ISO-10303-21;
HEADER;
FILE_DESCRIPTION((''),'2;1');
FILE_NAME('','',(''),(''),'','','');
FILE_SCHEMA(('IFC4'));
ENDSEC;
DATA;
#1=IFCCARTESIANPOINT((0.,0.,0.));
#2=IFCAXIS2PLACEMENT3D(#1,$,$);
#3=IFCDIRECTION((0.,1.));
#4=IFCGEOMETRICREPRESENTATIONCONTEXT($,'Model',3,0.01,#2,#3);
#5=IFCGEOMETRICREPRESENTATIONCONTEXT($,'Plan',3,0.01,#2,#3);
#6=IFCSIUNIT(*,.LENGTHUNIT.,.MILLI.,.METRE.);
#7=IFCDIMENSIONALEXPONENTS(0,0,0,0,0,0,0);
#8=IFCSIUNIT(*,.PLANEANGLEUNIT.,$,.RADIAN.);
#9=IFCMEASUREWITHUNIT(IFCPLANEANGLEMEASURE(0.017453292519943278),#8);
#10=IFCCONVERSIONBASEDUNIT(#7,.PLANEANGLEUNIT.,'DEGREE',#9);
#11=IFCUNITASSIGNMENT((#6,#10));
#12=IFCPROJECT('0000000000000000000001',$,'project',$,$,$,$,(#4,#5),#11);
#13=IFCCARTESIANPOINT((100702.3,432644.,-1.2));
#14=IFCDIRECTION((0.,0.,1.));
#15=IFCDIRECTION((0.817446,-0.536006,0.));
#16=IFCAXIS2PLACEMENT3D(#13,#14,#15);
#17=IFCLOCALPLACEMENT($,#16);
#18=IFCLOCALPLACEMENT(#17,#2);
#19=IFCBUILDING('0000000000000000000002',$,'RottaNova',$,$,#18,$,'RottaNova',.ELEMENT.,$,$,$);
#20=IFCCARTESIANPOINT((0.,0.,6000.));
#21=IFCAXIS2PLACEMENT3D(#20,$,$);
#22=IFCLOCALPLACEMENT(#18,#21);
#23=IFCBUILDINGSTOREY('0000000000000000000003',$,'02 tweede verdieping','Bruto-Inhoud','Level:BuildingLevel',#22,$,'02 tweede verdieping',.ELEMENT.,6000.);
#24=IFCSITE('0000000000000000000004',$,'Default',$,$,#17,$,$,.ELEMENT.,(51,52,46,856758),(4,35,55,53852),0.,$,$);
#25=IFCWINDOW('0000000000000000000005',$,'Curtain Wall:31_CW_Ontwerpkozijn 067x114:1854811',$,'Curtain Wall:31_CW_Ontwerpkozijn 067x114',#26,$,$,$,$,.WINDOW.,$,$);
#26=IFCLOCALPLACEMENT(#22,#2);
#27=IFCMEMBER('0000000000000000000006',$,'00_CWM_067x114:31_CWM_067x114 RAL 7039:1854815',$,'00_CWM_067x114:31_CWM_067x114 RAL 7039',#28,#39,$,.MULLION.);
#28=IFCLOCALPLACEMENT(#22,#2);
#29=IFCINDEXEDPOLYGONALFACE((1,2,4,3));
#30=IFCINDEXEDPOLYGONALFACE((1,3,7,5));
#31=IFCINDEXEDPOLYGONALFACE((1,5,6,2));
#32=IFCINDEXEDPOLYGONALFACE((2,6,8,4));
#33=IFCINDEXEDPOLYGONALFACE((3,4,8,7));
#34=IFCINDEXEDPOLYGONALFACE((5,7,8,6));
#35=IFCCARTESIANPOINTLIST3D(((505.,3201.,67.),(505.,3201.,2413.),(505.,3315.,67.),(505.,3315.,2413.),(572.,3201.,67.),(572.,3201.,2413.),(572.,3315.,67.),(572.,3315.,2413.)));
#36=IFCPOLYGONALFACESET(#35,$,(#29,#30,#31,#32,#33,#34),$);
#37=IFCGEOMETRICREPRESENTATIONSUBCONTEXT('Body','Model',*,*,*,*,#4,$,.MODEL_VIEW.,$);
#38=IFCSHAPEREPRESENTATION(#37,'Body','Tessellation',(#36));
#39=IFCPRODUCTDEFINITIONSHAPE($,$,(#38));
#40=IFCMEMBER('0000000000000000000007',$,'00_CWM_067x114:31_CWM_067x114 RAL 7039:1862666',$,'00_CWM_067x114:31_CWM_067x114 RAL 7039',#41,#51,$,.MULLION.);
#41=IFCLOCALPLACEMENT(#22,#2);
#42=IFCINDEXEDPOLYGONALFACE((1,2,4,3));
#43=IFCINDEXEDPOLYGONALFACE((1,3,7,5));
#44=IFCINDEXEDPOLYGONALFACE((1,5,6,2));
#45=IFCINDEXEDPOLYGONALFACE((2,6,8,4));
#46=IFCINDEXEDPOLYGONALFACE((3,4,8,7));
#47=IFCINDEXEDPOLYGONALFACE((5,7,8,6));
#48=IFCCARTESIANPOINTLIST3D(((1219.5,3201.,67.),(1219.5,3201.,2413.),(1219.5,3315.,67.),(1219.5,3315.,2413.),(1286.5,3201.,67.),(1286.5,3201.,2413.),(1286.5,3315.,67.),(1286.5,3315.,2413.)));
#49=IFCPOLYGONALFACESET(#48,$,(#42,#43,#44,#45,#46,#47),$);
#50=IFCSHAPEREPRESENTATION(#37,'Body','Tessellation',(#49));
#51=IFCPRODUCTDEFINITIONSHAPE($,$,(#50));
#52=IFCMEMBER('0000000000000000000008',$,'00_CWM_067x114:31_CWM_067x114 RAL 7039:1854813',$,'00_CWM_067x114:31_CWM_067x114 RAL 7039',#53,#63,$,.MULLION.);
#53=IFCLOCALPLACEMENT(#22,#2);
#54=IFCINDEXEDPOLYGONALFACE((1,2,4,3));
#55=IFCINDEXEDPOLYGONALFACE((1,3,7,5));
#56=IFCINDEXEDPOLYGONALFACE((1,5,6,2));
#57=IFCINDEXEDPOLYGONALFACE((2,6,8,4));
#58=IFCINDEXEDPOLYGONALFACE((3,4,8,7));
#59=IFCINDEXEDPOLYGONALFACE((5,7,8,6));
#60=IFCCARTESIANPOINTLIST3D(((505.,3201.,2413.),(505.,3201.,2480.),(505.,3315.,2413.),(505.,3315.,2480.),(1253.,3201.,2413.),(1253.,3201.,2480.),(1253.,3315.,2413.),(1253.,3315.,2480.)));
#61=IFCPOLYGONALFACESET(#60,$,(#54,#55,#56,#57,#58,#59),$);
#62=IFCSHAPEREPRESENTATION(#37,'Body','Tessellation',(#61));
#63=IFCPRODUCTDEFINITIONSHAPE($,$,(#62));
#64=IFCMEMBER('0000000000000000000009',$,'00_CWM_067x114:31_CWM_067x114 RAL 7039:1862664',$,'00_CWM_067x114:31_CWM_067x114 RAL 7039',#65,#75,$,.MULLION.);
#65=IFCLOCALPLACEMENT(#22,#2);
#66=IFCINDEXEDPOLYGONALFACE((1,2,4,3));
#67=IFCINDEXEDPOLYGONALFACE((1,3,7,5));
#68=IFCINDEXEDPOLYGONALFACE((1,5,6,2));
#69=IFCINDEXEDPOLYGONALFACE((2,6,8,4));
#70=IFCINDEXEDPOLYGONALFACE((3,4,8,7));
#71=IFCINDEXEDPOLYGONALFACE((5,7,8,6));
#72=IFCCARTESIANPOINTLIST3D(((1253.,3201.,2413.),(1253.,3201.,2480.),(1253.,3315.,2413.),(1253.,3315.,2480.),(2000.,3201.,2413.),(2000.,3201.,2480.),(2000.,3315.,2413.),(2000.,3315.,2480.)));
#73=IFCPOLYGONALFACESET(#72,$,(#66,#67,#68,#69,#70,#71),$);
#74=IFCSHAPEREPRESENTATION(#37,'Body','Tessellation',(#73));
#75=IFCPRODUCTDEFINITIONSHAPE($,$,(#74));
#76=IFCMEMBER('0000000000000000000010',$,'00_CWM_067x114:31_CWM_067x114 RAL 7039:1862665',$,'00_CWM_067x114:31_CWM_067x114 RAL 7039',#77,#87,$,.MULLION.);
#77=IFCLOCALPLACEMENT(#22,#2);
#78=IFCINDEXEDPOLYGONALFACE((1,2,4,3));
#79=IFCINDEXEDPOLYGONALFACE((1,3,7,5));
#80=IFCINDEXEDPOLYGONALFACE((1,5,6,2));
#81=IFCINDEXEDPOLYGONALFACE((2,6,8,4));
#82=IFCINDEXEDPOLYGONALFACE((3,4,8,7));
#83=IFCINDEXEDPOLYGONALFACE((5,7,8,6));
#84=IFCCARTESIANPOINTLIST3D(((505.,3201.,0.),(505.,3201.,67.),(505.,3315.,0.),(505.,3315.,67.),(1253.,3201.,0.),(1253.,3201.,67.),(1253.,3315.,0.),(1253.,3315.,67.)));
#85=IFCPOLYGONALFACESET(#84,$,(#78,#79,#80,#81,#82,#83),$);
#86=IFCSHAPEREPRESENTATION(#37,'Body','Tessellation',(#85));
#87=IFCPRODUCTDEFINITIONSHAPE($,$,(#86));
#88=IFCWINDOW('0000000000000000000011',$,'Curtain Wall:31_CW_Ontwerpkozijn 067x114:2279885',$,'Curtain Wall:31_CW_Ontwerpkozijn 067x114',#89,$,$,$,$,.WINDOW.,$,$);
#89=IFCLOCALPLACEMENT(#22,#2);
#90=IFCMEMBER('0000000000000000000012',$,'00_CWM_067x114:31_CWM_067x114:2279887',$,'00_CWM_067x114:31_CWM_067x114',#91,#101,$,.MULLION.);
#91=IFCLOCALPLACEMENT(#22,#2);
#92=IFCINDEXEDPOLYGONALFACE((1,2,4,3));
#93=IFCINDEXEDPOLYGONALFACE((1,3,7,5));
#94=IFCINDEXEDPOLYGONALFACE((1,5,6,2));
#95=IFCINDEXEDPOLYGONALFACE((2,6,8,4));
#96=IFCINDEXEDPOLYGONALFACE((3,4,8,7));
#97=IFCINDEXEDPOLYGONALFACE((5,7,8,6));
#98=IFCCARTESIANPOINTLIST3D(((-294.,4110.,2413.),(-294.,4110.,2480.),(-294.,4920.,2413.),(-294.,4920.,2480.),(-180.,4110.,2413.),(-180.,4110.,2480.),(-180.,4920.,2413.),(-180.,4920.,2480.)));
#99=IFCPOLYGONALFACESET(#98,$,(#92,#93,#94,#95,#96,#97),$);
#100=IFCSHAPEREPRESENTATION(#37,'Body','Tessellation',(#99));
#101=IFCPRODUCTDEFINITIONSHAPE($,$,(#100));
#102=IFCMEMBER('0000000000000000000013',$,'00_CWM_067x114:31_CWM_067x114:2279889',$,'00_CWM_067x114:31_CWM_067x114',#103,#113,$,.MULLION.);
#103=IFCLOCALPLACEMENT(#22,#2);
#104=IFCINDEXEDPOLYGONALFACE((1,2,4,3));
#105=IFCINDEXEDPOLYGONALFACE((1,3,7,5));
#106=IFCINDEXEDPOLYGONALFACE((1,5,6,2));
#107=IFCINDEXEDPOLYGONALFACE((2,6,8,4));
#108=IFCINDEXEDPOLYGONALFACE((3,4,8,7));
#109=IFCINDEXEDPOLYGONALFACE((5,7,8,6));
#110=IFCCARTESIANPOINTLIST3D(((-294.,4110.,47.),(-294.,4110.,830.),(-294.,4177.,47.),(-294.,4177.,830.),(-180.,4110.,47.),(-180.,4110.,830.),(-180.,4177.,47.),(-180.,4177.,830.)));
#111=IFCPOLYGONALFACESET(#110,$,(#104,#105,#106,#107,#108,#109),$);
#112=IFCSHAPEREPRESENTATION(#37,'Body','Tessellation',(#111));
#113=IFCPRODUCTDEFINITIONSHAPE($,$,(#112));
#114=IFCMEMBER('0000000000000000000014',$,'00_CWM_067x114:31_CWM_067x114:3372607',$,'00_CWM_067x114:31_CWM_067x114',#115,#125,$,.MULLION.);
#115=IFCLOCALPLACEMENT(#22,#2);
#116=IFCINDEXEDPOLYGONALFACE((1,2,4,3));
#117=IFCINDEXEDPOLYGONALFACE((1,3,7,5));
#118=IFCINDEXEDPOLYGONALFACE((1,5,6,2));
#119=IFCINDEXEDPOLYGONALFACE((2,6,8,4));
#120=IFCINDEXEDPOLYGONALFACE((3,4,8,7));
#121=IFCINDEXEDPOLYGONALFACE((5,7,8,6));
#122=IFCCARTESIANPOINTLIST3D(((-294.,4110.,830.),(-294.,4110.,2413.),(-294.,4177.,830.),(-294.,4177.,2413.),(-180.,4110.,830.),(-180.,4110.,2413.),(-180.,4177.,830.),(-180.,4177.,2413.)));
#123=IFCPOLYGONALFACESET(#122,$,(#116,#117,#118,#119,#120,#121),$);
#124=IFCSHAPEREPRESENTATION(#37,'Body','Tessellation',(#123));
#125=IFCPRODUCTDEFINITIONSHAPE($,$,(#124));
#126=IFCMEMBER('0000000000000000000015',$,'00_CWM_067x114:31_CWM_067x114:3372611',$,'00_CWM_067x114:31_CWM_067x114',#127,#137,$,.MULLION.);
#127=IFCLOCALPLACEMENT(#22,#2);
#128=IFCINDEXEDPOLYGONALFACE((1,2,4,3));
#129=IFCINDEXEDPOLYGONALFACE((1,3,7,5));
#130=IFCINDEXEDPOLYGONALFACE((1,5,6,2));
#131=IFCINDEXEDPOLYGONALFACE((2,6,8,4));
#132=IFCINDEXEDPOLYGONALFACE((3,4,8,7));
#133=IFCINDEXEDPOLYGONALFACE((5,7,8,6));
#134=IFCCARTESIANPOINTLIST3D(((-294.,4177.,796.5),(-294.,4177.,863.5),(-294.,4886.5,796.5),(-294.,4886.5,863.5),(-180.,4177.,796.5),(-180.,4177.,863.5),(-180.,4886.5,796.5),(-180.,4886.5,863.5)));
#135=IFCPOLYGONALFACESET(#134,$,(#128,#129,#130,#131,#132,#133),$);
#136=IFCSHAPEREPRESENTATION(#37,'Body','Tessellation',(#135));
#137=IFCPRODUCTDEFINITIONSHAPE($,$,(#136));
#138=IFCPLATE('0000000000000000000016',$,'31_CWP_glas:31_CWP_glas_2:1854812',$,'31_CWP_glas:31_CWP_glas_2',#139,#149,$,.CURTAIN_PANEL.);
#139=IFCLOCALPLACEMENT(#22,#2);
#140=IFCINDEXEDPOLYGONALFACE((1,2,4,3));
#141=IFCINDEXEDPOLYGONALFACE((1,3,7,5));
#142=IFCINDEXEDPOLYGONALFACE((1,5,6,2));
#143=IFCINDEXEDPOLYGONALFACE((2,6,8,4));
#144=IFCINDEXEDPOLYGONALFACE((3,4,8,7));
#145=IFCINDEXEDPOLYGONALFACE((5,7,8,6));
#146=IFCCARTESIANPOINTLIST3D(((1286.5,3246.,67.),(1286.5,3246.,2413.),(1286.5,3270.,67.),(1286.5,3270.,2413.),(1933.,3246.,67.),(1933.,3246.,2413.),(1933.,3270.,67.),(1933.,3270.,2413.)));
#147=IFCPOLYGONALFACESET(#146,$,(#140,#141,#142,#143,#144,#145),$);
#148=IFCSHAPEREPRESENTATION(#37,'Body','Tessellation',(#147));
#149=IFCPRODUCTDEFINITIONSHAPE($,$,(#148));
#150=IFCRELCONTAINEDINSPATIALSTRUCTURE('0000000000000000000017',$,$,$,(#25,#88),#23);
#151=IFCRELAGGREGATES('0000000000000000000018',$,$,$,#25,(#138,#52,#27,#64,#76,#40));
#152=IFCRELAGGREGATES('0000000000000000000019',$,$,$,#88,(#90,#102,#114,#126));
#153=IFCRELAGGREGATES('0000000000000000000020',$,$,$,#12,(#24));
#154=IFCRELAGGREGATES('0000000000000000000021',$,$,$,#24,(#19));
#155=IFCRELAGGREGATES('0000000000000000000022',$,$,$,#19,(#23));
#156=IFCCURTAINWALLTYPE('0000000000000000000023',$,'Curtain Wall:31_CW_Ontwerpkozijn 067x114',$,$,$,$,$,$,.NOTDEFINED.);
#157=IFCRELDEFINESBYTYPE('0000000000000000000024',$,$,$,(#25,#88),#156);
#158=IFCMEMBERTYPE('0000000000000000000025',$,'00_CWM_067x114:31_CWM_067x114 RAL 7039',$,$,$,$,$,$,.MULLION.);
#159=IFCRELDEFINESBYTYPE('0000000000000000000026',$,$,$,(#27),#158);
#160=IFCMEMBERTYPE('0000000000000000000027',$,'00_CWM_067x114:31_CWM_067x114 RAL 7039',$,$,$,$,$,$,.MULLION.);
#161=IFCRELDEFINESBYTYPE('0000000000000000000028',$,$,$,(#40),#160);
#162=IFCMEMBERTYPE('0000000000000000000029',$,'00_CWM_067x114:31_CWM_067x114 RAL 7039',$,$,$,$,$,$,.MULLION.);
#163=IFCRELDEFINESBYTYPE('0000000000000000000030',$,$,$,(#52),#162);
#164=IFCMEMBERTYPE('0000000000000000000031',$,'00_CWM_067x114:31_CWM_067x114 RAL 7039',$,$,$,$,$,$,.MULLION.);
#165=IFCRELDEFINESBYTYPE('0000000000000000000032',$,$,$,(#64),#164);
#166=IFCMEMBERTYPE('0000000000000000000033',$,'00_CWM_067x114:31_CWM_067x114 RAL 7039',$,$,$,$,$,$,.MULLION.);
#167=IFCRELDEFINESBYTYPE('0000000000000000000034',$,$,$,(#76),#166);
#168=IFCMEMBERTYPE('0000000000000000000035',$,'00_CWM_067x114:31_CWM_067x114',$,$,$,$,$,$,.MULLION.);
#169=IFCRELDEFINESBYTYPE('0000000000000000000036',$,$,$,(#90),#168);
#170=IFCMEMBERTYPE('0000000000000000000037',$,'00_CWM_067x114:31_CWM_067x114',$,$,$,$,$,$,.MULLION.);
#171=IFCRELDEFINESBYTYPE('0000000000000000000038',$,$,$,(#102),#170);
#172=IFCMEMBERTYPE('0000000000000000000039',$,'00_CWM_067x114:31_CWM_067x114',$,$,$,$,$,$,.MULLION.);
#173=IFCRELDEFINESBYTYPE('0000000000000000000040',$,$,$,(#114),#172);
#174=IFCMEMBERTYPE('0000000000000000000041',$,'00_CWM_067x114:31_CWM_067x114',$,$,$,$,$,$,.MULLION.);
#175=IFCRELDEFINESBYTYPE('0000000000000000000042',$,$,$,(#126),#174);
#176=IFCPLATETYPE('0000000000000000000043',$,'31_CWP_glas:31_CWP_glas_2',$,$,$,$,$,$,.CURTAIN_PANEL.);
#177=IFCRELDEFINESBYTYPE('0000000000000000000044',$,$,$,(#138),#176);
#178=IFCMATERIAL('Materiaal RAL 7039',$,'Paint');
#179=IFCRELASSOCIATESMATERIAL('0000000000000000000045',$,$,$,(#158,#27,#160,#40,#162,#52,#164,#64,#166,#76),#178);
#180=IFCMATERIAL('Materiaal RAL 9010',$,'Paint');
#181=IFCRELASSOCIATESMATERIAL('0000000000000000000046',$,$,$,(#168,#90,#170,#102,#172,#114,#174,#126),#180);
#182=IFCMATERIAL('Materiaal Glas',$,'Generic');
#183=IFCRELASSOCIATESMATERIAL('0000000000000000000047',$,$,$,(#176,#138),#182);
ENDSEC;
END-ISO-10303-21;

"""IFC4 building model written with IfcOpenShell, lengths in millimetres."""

from ifc_helpers import new_model, entity, si_unit, converted_unit, direction, frame, origin, place, context, subcontext, project, spatial, indexed_curve, outline, extrude, source, transform, mapped, material, type_object, type_shapes, element, aggregate, save


model = new_model("IFC4")

# Units and contexts
model_context = context("Model", 3, precision=0.01, world=origin(), true_north=direction((0.0, 1.0)))
plan_context = context("Plan", 3, precision=0.01, world=origin(), true_north=direction((0.0, 1.0)))
body_context = subcontext(model_context, "Body", "Model", "MODEL_VIEW")
ifc_project = project(units=[si_unit("LENGTHUNIT", "METRE", prefix="MILLI"), converted_unit("PLANEANGLEUNIT", "DEGREE", entity("IfcPlaneAngleMeasure", 0.017453292519943278), si_unit("PLANEANGLEUNIT", "RADIAN"), dimensions=[0, 0, 0, 0, 0, 0, 0])], contexts=[model_context, plan_context])

# Site, building, storey
site_placement = place(None, frame((100702.3, 432644.0, -1.2), z_axis=(0.0, 0.0, 1.0), x_axis=(0.817446, -0.536006, 0.0)))
site = spatial("IfcSite", under=ifc_project, at=site_placement, Name="Default", CompositionType="ELEMENT", RefLatitude=(51, 52, 46, 856758), RefLongitude=(4, 35, 55, 53852), RefElevation=0.0)
building_placement = place(site_placement, origin())
building = spatial("IfcBuilding", under=site, at=building_placement, Name="RottaNova", LongName="RottaNova", CompositionType="ELEMENT")
storey_placement = place(building_placement, frame((0.0, 0.0, 6000.0)))
storey = spatial("IfcBuildingStorey", under=building, at=storey_placement, Name="02 tweede verdieping", Description="Bruto-Inhoud", ObjectType="Level:BuildingLevel", LongName="02 tweede verdieping", CompositionType="ELEMENT", Elevation=6000.0)

# Windows, members
curtain_wall_type = type_object("IfcCurtainWallType", Name="Curtain Wall:31_CW_Ontwerpkozijn 067x114", PredefinedType="NOTDEFINED")
window_1_placement = place(storey_placement, frame((0.0, 0.0, -6000.0)))
window_1 = element("IfcWindow", 1, at=window_1_placement, inside=storey, type_object=curtain_wall_type, Name="Curtain Wall:31_CW_Ontwerpkozijn 067x114:1854811", ObjectType="Curtain Wall:31_CW_Ontwerpkozijn 067x114", PredefinedType="WINDOW")
ifc_material_1 = material(Name="Materiaal RAL 7039", Category="Paint")
member_type_1 = type_object("IfcMemberType", Name="00_CWM_067x114:31_CWM_067x114 RAL 7039", PredefinedType="MULLION", material=ifc_material_1)
shared_shape_1 = source(origin(), body_context, "Body", "SweptSolid", [
    extrude(outline(indexed_curve([(-33.5, -57.0), (33.5, -57.0), (33.5, 57.0), (-33.5, 57.0), (-33.5, -57.0)], self_intersect=False)), frame((-33.5, -57.0, -2346.0), z_axis=(0.0, 0.0, 1.0), x_axis=(-1.0, 0.0, 0.0)), (0.0, 0.0, 1.0), 2346.0),
])
type_shapes(member_type_1, [shared_shape_1])
member_1_placement = place(window_1_placement, frame((505.0, 3315.0, 6067.0), z_axis=(0.0, 0.0, -1.0), x_axis=(-1.0, 0.0, 0.0)))
member_1 = element("IfcMember", 2, at=member_1_placement, type_object=member_type_1, material=ifc_material_1, Name="00_CWM_067x114:31_CWM_067x114 RAL 7039:1854815", ObjectType="00_CWM_067x114:31_CWM_067x114 RAL 7039", PredefinedType="MULLION", context=body_context, shape_type="MappedRepresentation", body=[
    mapped(shared_shape_1, transform((0.0, 0.0, 0.0), scale=1.0)),
])
member_type_2 = type_object("IfcMemberType", Name="00_CWM_067x114:31_CWM_067x114 RAL 7039", PredefinedType="MULLION", material=ifc_material_1)
shared_shape_2 = source(origin(), body_context, "Body", "SweptSolid", [
    extrude(outline(indexed_curve([(-33.5, -57.0), (33.5, -57.0), (33.5, 57.0), (-33.5, 57.0), (-33.5, -57.0)], self_intersect=False)), frame((0.0, -57.0, -2346.0), z_axis=(0.0, 0.0, 1.0), x_axis=(-1.0, 0.0, 0.0)), (0.0, 0.0, 1.0), 2346.0),
])
type_shapes(member_type_2, [shared_shape_2])
member_2_placement = place(window_1_placement, frame((1253.0, 3315.0, 6067.0), z_axis=(0.0, 0.0, -1.0), x_axis=(-1.0, 0.0, 0.0)))
member_2 = element("IfcMember", 3, at=member_2_placement, type_object=member_type_2, material=ifc_material_1, Name="00_CWM_067x114:31_CWM_067x114 RAL 7039:1862666", ObjectType="00_CWM_067x114:31_CWM_067x114 RAL 7039", PredefinedType="MULLION", context=body_context, shape_type="MappedRepresentation", body=[
    mapped(shared_shape_2, transform((0.0, 0.0, 0.0), scale=1.0)),
])
member_type_3 = type_object("IfcMemberType", Name="00_CWM_067x114:31_CWM_067x114 RAL 7039", PredefinedType="MULLION", material=ifc_material_1)
shared_shape_3 = source(origin(), body_context, "Body", "SweptSolid", [
    extrude(outline(indexed_curve([(-33.5, -57.0), (33.5, -57.0), (33.5, 57.0), (-33.5, 57.0), (-33.5, -57.0)], self_intersect=False)), frame((-33.5, -57.0, -748.0), z_axis=(0.0, 0.0, 1.0), x_axis=(-1.0, 0.0, 0.0)), (0.0, 0.0, 1.0), 748.0),
])
type_shapes(member_type_3, [shared_shape_3])
member_3_placement = place(window_1_placement, frame((505.0, 3315.0, 8480.0), z_axis=(-1.0, 0.0, 0.0), x_axis=(0.0, 0.0, 1.0)))
member_3 = element("IfcMember", 4, at=member_3_placement, type_object=member_type_3, material=ifc_material_1, Name="00_CWM_067x114:31_CWM_067x114 RAL 7039:1854813", ObjectType="00_CWM_067x114:31_CWM_067x114 RAL 7039", PredefinedType="MULLION", context=body_context, shape_type="MappedRepresentation", body=[
    mapped(shared_shape_3, transform((0.0, 0.0, 0.0), scale=1.0)),
])
member_type_4 = type_object("IfcMemberType", Name="00_CWM_067x114:31_CWM_067x114 RAL 7039", PredefinedType="MULLION", material=ifc_material_1)
shared_shape_4 = source(origin(), body_context, "Body", "SweptSolid", [
    extrude(outline(indexed_curve([(-33.5, -57.0), (33.5, -57.0), (33.5, 57.0), (-33.5, 57.0), (-33.5, -57.0)], self_intersect=False)), frame((-33.5, -57.0, -747.0), z_axis=(0.0, 0.0, 1.0), x_axis=(-1.0, 0.0, 0.0)), (0.0, 0.0, 1.0), 747.0),
])
type_shapes(member_type_4, [shared_shape_4])
member_4_placement = place(window_1_placement, frame((1253.0, 3315.0, 8480.0), z_axis=(-1.0, 0.0, 0.0), x_axis=(0.0, 0.0, 1.0)))
member_4 = element("IfcMember", 5, at=member_4_placement, type_object=member_type_4, material=ifc_material_1, Name="00_CWM_067x114:31_CWM_067x114 RAL 7039:1862664", ObjectType="00_CWM_067x114:31_CWM_067x114 RAL 7039", PredefinedType="MULLION", context=body_context, shape_type="MappedRepresentation", body=[
    mapped(shared_shape_4, transform((0.0, 0.0, 0.0), scale=1.0)),
])
member_type_5 = type_object("IfcMemberType", Name="00_CWM_067x114:31_CWM_067x114 RAL 7039", PredefinedType="MULLION", material=ifc_material_1)
shared_shape_5 = source(origin(), body_context, "Body", "SweptSolid", [
    extrude(outline(indexed_curve([(-33.5, -57.0), (33.5, -57.0), (33.5, 57.0), (-33.5, 57.0), (-33.5, -57.0)], self_intersect=False)), frame((-33.5, -57.0, -748.0), z_axis=(0.0, 0.0, 1.0), x_axis=(-1.0, 0.0, 0.0)), (0.0, 0.0, 1.0), 748.0),
])
type_shapes(member_type_5, [shared_shape_5])
member_5_placement = place(window_1_placement, frame((1253.0, 3315.0, 6000.0), z_axis=(1.0, 0.0, 0.0), x_axis=(0.0, 0.0, -1.0)))
member_5 = element("IfcMember", 6, at=member_5_placement, type_object=member_type_5, material=ifc_material_1, Name="00_CWM_067x114:31_CWM_067x114 RAL 7039:1862665", ObjectType="00_CWM_067x114:31_CWM_067x114 RAL 7039", PredefinedType="MULLION", context=body_context, shape_type="MappedRepresentation", body=[
    mapped(shared_shape_5, transform((0.0, 0.0, 0.0), scale=1.0)),
])
window_2_placement = place(storey_placement, frame((0.0, 0.0, -6000.0)))
window_2 = element("IfcWindow", 7, at=window_2_placement, inside=storey, type_object=curtain_wall_type, Name="Curtain Wall:31_CW_Ontwerpkozijn 067x114:2279885", ObjectType="Curtain Wall:31_CW_Ontwerpkozijn 067x114", PredefinedType="WINDOW")
ifc_material_2 = material(Name="Materiaal RAL 9010", Category="Paint")
member_type_6 = type_object("IfcMemberType", Name="00_CWM_067x114:31_CWM_067x114", PredefinedType="MULLION", material=ifc_material_2)
shared_shape_6 = source(origin(), body_context, "Body", "SweptSolid", [
    extrude(outline(indexed_curve([(-33.5, -57.0), (33.5, -57.0), (33.5, 57.0), (-33.5, 57.0), (-33.5, -57.0)], self_intersect=False)), frame((-33.5, 57.0, -810.0), z_axis=(0.0, 0.0, 1.0), x_axis=(-1.0, 0.0, 0.0)), (0.0, 0.0, 1.0), 810.0),
])
type_shapes(member_type_6, [shared_shape_6])
member_6_placement = place(window_2_placement, frame((-180.0, 4110.0, 8480.0), z_axis=(0.0, -1.0, 0.0), x_axis=(0.0, 0.0, 1.0)))
member_6 = element("IfcMember", 8, at=member_6_placement, type_object=member_type_6, material=ifc_material_2, Name="00_CWM_067x114:31_CWM_067x114:2279887", ObjectType="00_CWM_067x114:31_CWM_067x114", PredefinedType="MULLION", context=body_context, shape_type="MappedRepresentation", body=[
    mapped(shared_shape_6, transform((0.0, 0.0, 0.0), scale=1.0)),
])
member_type_7 = type_object("IfcMemberType", Name="00_CWM_067x114:31_CWM_067x114", PredefinedType="MULLION", material=ifc_material_2)
shared_shape_7 = source(origin(), body_context, "Body", "SweptSolid", [
    extrude(outline(indexed_curve([(-33.5, -57.0), (33.5, -57.0), (33.5, 57.0), (-33.5, 57.0), (-33.5, -57.0)], self_intersect=False)), frame((-33.5, 57.0, -783.0), z_axis=(0.0, 0.0, 1.0), x_axis=(-1.0, 0.0, 0.0)), (0.0, 0.0, 1.0), 783.0),
])
type_shapes(member_type_7, [shared_shape_7])
member_7_placement = place(window_2_placement, frame((-180.0, 4110.0, 6047.0), z_axis=(0.0, 0.0, -1.0), x_axis=(0.0, -1.0, 0.0)))
member_7 = element("IfcMember", 9, at=member_7_placement, type_object=member_type_7, material=ifc_material_2, Name="00_CWM_067x114:31_CWM_067x114:2279889", ObjectType="00_CWM_067x114:31_CWM_067x114", PredefinedType="MULLION", context=body_context, shape_type="MappedRepresentation", body=[
    mapped(shared_shape_7, transform((0.0, 0.0, 0.0), scale=1.0)),
])
member_type_8 = type_object("IfcMemberType", Name="00_CWM_067x114:31_CWM_067x114", PredefinedType="MULLION", material=ifc_material_2)
shared_shape_8 = source(origin(), body_context, "Body", "SweptSolid", [
    extrude(outline(indexed_curve([(-33.5, -57.0), (33.5, -57.0), (33.5, 57.0), (-33.5, 57.0), (-33.5, -57.0)], self_intersect=False)), frame((-33.5, 57.0, -1583.0), z_axis=(0.0, 0.0, 1.0), x_axis=(-1.0, 0.0, 0.0)), (0.0, 0.0, 1.0), 1583.0),
])
type_shapes(member_type_8, [shared_shape_8])
member_8_placement = place(window_2_placement, frame((-180.0, 4110.0, 6830.0), z_axis=(0.0, 0.0, -1.0), x_axis=(0.0, -1.0, 0.0)))
member_8 = element("IfcMember", 10, at=member_8_placement, type_object=member_type_8, material=ifc_material_2, Name="00_CWM_067x114:31_CWM_067x114:3372607", ObjectType="00_CWM_067x114:31_CWM_067x114", PredefinedType="MULLION", context=body_context, shape_type="MappedRepresentation", body=[
    mapped(shared_shape_8, transform((0.0, 0.0, 0.0), scale=1.0)),
])
member_type_9 = type_object("IfcMemberType", Name="00_CWM_067x114:31_CWM_067x114", PredefinedType="MULLION", material=ifc_material_2)
shared_shape_9 = source(origin(), body_context, "Body", "SweptSolid", [
    extrude(outline(indexed_curve([(-33.5, -57.0), (33.5, -57.0), (33.5, 57.0), (-33.5, 57.0), (-33.5, -57.0)], self_intersect=False)), frame((0.0, 57.0, -709.5), z_axis=(0.0, 0.0, 1.0), x_axis=(-1.0, 0.0, 0.0)), (0.0, 0.0, 1.0), 709.5),
])
type_shapes(member_type_9, [shared_shape_9])
member_9_placement = place(window_2_placement, frame((-180.0, 4177.0, 6830.0), z_axis=(0.0, -1.0, 0.0), x_axis=(0.0, 0.0, 1.0)))
member_9 = element("IfcMember", 11, at=member_9_placement, type_object=member_type_9, material=ifc_material_2, Name="00_CWM_067x114:31_CWM_067x114:3372611", ObjectType="00_CWM_067x114:31_CWM_067x114", PredefinedType="MULLION", context=body_context, shape_type="MappedRepresentation", body=[
    mapped(shared_shape_9, transform((0.0, 0.0, 0.0), scale=1.0)),
])

# Plate
ifc_material_3 = material(Name="Materiaal Glas", Category="Generic")
plate_type_1 = type_object("IfcPlateType", Name="31_CWP_glas:31_CWP_glas_2", PredefinedType="CURTAIN_PANEL", material=ifc_material_3)
shared_shape_10 = source(origin(), body_context, "Body", "SweptSolid", [
    extrude(outline(indexed_curve([(-12.0, -323.2), (12.0, -323.2), (12.0, 323.2), (-12.0, 323.2), (-12.0, -323.2)], self_intersect=False)), frame((0.0, 57.0, 0.0), z_axis=(0.0, 0.0, 1.0), x_axis=(0.0, 1.0, 0.0)), (0.0, 0.0, 1.0), 2346.0),
])
type_shapes(plate_type_1, [shared_shape_10])
plate_1_placement = place(window_1_placement, frame((1609.8, 3315.0, 6067.0), z_axis=(0.0, 0.0, 1.0), x_axis=(-1.0, 0.0, 0.0)))
plate_1 = element("IfcPlate", 12, at=plate_1_placement, type_object=plate_type_1, material=ifc_material_3, Name="31_CWP_glas:31_CWP_glas_2:1854812", ObjectType="31_CWP_glas:31_CWP_glas_2", PredefinedType="CURTAIN_PANEL", context=body_context, shape_type="MappedRepresentation", body=[
    mapped(shared_shape_10, transform((0.0, 0.0, 0.0), scale=1.0)),
])
aggregate(window_1, [plate_1, member_3, member_1, member_4, member_5, member_2])
aggregate(window_2, [member_6, member_7, member_8, member_9])

save(model, "model.ifc")
